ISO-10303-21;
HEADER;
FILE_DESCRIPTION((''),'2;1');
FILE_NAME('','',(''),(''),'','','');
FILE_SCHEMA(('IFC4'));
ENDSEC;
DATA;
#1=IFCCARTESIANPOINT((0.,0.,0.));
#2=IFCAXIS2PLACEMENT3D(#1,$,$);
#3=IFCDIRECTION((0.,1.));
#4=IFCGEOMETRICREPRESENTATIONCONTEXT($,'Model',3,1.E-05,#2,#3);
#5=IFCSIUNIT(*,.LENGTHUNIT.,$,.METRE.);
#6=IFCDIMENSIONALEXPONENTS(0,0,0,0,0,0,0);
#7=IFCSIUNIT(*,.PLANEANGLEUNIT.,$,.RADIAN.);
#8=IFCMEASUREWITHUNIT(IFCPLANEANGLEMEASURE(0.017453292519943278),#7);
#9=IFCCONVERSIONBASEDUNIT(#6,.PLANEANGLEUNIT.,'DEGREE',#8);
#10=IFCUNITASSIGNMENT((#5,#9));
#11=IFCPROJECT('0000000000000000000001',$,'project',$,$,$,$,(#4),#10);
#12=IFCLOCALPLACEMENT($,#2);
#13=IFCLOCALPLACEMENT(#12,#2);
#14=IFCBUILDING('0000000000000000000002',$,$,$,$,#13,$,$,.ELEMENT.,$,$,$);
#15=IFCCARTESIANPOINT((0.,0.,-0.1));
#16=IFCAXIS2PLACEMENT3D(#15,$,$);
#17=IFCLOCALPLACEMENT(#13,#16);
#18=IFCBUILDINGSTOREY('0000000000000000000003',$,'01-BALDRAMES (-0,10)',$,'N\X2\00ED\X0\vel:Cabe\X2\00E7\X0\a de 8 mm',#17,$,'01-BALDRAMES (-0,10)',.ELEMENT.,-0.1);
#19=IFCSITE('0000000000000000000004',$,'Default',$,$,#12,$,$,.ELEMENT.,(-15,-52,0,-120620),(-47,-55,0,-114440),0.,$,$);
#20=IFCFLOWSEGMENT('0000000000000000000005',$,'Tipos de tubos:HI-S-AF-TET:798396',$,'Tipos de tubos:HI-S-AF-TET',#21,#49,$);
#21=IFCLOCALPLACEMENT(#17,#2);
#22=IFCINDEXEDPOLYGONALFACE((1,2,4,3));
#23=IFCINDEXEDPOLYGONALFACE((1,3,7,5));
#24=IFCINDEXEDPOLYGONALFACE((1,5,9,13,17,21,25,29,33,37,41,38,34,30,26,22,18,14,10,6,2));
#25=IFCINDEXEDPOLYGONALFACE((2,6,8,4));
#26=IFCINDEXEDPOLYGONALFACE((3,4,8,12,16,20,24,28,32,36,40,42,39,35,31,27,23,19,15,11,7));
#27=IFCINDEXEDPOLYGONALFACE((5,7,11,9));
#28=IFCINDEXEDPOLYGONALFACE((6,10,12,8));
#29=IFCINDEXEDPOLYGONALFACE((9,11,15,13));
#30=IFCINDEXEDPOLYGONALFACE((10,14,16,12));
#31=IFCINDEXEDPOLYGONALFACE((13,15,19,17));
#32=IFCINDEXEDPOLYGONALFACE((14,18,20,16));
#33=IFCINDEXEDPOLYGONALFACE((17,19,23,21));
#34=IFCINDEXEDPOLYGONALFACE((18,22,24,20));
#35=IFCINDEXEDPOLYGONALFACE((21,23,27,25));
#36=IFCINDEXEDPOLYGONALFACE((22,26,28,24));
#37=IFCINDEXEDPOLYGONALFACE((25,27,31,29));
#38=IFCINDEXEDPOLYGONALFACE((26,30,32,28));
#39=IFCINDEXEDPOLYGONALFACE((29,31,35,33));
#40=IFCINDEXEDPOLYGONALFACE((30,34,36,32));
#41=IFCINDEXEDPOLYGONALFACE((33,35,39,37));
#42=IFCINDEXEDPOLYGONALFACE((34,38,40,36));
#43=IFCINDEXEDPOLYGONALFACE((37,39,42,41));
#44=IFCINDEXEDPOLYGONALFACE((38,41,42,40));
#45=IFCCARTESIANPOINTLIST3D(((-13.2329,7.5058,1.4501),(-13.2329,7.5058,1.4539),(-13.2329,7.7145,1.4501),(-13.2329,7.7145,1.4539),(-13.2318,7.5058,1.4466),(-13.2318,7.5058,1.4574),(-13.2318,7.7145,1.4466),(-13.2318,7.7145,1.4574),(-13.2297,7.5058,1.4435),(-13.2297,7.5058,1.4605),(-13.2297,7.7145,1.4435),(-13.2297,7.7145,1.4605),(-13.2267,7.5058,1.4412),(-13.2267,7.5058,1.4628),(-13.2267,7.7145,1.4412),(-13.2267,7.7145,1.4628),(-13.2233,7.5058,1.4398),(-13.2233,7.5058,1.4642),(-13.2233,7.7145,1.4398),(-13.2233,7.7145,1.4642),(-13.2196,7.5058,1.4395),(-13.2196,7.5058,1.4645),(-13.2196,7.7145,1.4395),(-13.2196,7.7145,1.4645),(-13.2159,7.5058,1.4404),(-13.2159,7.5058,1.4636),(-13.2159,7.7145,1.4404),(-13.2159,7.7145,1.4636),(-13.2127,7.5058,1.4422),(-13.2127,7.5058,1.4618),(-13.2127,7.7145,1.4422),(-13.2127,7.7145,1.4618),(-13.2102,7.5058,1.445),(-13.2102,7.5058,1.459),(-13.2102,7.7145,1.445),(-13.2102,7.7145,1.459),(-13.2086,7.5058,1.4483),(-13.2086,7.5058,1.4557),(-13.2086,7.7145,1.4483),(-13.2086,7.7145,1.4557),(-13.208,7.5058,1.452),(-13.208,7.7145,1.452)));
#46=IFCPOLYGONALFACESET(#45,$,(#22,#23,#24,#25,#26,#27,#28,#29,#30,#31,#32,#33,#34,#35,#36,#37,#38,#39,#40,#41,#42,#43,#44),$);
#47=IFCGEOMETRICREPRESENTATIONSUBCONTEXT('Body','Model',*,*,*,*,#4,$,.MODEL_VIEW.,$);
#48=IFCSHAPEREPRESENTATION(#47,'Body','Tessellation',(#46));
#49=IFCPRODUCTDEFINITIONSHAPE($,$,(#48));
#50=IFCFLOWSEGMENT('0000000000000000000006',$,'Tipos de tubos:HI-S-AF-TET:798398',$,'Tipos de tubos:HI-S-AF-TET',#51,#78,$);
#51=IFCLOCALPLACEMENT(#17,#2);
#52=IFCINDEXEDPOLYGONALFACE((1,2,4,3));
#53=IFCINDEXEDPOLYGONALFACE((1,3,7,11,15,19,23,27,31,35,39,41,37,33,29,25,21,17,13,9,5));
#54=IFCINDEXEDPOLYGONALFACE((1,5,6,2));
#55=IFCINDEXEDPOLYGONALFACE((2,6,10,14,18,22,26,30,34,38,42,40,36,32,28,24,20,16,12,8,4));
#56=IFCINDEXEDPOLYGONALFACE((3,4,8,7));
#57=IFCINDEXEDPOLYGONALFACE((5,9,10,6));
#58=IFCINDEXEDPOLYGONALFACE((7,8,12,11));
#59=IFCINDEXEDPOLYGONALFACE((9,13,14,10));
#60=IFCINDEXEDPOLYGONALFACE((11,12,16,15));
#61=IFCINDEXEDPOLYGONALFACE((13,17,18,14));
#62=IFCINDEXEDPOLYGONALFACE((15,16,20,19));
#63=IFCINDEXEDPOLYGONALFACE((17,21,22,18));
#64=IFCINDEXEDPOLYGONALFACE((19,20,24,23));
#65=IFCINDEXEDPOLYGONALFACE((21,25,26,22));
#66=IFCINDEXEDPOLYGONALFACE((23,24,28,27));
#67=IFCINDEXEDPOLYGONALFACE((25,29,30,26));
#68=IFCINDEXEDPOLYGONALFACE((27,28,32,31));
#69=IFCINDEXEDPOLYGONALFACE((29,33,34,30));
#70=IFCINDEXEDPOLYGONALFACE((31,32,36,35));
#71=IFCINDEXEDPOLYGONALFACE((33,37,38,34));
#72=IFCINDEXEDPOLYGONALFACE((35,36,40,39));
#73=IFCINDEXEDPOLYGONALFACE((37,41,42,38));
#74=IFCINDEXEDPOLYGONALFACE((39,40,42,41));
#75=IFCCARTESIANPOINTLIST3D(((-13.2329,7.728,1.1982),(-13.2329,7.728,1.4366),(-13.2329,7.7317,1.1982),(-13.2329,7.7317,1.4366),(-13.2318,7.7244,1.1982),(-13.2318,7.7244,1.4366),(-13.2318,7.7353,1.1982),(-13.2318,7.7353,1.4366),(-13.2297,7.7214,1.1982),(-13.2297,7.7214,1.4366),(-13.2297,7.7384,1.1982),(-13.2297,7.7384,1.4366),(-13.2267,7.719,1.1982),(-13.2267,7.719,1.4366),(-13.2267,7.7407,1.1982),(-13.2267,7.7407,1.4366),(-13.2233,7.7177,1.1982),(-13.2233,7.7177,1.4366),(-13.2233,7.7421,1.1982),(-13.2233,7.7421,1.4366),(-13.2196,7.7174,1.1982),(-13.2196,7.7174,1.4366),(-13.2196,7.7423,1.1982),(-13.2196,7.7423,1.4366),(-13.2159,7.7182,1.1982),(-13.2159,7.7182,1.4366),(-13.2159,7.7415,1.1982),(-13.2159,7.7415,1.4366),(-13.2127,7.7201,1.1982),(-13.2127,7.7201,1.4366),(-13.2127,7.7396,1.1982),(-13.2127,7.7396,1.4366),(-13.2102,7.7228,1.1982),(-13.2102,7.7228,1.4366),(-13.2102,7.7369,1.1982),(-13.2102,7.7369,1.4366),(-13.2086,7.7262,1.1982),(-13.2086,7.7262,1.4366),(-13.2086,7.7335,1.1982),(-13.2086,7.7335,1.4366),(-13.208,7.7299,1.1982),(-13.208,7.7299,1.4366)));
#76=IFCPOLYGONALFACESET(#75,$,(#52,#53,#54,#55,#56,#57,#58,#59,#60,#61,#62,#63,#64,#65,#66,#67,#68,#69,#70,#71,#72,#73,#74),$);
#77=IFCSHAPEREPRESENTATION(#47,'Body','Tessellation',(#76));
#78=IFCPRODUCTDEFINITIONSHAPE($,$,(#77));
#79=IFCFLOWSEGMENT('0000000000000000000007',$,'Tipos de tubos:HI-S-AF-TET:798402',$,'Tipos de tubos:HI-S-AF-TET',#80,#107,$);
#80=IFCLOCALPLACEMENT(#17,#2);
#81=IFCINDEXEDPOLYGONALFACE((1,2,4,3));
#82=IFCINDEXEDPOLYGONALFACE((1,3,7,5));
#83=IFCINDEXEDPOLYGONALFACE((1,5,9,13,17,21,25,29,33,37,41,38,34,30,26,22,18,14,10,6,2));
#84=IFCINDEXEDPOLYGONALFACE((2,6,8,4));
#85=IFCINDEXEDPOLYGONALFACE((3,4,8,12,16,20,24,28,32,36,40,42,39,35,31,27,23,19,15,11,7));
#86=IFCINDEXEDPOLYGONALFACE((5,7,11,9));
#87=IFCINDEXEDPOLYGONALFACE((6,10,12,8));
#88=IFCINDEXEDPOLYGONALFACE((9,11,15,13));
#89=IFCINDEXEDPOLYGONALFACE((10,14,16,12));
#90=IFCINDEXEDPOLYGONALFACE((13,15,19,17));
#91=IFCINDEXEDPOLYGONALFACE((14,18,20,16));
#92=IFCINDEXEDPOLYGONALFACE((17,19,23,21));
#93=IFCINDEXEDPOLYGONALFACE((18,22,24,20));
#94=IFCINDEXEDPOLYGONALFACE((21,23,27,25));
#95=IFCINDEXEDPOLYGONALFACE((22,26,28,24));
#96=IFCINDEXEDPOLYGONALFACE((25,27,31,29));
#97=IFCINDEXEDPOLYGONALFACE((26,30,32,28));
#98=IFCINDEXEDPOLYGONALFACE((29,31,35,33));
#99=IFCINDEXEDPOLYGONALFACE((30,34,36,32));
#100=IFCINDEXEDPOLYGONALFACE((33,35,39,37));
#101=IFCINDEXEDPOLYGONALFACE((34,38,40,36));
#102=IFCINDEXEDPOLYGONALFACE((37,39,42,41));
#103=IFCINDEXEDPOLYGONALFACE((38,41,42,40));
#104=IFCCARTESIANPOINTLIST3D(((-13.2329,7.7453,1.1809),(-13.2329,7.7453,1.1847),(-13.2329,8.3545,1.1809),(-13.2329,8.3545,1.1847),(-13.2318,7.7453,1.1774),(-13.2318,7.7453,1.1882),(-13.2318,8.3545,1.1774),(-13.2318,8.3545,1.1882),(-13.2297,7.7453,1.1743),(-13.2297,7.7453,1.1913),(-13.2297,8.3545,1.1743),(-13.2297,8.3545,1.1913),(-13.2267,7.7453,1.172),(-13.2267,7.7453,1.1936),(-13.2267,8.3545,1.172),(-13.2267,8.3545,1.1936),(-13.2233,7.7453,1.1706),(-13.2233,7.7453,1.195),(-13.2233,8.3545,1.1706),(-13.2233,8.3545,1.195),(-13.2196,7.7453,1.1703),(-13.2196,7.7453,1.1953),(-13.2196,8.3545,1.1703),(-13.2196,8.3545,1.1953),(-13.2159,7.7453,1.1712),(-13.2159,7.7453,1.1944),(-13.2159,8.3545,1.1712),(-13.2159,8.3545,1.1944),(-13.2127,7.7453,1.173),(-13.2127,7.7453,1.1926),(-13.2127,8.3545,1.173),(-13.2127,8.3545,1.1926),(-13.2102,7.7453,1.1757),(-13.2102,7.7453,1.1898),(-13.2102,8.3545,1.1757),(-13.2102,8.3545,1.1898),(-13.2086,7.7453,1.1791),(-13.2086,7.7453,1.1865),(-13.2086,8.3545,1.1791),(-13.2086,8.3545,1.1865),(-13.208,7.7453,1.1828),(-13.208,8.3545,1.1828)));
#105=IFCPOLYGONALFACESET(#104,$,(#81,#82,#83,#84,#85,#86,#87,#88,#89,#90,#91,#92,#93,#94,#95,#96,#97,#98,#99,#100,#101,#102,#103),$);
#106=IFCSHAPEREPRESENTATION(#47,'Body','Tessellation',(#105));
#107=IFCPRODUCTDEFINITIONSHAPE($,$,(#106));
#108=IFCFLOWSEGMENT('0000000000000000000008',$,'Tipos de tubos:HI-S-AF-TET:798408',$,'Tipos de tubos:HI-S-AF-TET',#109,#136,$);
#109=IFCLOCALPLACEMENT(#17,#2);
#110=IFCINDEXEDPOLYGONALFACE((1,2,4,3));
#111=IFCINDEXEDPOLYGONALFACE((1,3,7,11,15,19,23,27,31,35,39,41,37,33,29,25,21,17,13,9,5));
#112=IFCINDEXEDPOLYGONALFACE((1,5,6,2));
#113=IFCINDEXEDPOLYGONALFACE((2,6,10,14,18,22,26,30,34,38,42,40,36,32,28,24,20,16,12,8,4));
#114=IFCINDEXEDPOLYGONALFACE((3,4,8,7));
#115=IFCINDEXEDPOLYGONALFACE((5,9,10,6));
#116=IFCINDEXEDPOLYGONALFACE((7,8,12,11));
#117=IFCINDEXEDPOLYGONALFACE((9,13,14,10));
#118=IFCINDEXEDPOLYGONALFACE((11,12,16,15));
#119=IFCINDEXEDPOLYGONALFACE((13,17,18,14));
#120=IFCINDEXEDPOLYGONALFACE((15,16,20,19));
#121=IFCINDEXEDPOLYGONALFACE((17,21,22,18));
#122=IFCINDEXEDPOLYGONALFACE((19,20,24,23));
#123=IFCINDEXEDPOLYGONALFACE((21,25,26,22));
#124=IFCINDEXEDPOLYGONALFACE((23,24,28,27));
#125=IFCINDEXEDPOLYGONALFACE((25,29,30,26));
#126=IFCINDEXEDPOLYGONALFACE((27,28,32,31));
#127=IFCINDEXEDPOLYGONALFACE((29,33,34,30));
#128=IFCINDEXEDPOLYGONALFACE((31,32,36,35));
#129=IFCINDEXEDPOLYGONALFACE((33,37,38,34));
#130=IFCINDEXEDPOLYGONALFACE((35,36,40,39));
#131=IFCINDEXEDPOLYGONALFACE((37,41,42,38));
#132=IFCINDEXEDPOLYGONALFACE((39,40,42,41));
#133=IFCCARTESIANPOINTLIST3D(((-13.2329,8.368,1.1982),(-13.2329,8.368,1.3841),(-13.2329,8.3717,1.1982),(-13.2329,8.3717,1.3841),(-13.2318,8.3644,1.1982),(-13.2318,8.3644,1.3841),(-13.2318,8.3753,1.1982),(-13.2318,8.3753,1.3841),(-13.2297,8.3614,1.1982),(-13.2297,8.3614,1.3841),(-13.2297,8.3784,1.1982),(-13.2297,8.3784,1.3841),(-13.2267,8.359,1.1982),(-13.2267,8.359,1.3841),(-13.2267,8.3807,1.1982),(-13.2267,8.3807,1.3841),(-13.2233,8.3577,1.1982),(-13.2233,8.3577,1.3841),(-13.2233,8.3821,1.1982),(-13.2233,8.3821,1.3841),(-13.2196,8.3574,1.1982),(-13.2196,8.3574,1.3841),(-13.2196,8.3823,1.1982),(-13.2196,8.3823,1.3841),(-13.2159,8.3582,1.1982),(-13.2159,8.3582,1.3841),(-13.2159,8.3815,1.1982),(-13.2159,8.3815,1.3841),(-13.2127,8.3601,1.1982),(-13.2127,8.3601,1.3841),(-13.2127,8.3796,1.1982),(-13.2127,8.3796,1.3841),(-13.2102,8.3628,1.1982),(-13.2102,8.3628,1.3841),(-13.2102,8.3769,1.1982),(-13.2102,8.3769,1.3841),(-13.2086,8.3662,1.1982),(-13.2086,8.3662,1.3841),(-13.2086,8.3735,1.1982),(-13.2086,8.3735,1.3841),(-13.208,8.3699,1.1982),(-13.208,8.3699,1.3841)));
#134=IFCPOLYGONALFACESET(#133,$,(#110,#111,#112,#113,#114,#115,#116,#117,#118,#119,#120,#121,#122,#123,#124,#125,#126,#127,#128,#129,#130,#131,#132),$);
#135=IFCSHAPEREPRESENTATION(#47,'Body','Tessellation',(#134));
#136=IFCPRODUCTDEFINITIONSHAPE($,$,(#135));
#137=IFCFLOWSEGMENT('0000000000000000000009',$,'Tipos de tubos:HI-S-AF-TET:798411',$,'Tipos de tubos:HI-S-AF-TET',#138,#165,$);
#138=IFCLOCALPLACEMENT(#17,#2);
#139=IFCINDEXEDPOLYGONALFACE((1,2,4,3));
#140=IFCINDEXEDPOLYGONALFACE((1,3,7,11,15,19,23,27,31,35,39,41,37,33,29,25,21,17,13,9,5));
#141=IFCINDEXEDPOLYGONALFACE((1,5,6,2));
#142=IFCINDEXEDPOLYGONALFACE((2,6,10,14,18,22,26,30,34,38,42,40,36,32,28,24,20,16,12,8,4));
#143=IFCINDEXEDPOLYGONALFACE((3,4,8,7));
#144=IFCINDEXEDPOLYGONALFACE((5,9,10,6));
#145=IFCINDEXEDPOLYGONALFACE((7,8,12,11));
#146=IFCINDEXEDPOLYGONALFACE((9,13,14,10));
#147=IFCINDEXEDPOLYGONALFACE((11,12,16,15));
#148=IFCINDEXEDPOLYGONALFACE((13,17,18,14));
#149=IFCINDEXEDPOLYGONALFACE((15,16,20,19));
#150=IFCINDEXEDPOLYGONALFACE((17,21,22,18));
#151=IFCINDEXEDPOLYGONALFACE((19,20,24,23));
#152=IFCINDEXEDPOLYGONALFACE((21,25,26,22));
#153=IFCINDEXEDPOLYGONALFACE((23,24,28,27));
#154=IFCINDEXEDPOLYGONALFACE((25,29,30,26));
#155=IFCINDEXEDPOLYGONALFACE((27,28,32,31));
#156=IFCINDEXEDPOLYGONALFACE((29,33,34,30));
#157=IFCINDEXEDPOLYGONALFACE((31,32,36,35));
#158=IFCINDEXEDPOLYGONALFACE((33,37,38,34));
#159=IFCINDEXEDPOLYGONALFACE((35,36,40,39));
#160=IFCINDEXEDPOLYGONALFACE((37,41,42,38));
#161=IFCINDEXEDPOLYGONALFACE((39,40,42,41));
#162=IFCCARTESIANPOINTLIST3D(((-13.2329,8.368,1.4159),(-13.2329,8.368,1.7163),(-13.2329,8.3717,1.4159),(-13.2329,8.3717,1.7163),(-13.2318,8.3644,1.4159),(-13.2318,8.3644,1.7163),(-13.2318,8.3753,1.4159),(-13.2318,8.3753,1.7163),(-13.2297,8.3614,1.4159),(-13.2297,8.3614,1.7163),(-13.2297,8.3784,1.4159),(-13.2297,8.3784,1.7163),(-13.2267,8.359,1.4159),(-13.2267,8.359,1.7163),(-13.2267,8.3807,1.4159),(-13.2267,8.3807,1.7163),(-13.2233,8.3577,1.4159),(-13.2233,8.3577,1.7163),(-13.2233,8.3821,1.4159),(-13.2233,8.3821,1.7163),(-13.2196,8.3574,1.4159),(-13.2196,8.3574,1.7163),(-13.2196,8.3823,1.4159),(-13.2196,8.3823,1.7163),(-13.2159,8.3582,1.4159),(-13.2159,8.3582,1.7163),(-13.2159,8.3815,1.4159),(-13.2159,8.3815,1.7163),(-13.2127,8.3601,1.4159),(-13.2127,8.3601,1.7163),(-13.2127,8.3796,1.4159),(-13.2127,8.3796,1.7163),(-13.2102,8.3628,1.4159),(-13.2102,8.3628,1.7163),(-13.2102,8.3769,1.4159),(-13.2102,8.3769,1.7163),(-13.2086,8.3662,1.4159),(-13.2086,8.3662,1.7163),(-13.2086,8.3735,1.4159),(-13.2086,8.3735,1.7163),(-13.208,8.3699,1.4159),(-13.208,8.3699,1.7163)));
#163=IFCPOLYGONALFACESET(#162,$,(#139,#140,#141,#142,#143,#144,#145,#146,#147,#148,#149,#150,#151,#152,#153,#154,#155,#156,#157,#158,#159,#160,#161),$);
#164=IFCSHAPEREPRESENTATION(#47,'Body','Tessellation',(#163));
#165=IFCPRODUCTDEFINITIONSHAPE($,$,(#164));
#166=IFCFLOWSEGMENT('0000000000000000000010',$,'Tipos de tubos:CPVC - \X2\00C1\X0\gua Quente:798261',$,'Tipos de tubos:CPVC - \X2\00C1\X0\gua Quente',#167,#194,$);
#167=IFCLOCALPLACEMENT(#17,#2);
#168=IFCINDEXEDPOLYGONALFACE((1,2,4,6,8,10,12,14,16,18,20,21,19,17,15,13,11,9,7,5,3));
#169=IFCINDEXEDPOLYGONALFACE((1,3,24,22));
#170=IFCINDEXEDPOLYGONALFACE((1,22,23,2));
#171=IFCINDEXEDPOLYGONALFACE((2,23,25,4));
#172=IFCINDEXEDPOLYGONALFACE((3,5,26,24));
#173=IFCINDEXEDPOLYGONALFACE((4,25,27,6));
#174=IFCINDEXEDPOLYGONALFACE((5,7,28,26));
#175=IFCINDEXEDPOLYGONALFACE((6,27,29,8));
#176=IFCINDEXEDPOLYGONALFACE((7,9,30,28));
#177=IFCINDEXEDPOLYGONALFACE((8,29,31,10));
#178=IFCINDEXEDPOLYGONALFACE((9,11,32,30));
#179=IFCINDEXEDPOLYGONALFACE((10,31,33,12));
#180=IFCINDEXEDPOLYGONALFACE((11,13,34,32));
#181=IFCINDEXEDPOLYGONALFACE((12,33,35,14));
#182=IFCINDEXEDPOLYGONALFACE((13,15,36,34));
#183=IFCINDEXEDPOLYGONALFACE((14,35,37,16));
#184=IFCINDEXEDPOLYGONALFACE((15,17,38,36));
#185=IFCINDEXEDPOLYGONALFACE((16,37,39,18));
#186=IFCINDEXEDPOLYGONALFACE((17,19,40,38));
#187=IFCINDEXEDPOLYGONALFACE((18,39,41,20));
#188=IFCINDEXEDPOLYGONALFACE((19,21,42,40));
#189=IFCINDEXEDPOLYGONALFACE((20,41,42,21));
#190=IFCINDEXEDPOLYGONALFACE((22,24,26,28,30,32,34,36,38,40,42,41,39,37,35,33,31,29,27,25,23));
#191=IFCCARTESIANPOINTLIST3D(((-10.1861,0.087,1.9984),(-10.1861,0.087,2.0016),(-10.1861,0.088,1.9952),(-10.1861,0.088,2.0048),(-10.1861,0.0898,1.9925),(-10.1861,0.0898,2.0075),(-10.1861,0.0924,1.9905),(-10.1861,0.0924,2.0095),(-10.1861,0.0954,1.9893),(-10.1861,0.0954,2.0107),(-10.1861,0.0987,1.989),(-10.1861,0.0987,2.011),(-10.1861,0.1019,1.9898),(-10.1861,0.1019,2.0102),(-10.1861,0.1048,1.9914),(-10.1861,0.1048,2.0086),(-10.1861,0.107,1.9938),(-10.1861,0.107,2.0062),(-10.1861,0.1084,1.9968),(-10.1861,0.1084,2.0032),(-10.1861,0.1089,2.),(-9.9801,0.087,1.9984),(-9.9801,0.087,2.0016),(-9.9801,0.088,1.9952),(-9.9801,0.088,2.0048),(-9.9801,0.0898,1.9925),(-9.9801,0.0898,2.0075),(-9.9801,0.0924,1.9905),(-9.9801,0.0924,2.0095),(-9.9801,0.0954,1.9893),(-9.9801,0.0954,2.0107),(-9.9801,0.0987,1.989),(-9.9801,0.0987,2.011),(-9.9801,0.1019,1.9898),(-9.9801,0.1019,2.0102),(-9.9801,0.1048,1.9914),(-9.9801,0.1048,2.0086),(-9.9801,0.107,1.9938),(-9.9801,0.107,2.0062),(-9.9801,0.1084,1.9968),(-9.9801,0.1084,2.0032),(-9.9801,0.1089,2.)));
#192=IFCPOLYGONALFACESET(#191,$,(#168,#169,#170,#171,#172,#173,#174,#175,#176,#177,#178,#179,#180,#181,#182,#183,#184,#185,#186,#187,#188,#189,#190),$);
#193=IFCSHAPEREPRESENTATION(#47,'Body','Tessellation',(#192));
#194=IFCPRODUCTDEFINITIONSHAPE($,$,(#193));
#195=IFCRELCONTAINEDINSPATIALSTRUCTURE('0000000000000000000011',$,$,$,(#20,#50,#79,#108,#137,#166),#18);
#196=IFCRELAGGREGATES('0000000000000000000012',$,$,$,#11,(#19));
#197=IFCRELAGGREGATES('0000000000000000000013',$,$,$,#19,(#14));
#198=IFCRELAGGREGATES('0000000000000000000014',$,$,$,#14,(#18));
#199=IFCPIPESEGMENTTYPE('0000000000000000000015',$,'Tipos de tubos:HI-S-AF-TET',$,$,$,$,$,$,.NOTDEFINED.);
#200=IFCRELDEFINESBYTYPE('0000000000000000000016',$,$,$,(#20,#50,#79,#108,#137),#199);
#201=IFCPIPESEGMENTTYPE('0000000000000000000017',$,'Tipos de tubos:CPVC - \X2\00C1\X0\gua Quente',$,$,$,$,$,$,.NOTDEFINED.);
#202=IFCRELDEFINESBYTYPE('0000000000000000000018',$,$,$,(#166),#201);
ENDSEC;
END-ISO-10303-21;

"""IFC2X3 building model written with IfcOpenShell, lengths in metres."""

from ifc_helpers import new_model, entity, si_unit, converted_unit, direction, frame, frame_2d, origin, origin_2d_with_axis, place, context, subcontext, project, spatial, circle, extrude, type_object, element, save


model = new_model("IFC2X3")

# Units and contexts
model_context = context("Model", 3, precision=1e-05, world=origin(), true_north=direction((0.0, 1.0)))
body_context = subcontext(model_context, "Body", "Model", "MODEL_VIEW")
ifc_project = project(units=[si_unit("LENGTHUNIT", "METRE"), converted_unit("PLANEANGLEUNIT", "DEGREE", entity("IfcPlaneAngleMeasure", 0.017453292519943278), si_unit("PLANEANGLEUNIT", "RADIAN"), dimensions=[0, 0, 0, 0, 0, 0, 0])], contexts=[model_context])

# Site, building, storey
site_placement = place(None, origin())
site = spatial("IfcSite", under=ifc_project, at=site_placement, Name="Default", CompositionType="ELEMENT", RefLatitude=(-15, -52, 0, -120620), RefLongitude=(-47, -55, 0, -114440), RefElevation=0.0)
building_placement = place(site_placement, origin())
building = spatial("IfcBuilding", under=site, at=building_placement, CompositionType="ELEMENT")
storey_placement = place(building_placement, frame((0.0, 0.0, -0.1)))
storey = spatial("IfcBuildingStorey", under=building, at=storey_placement, Name="01-BALDRAMES (-0,10)", ObjectType="Nível:Cabeça de 8 mm", LongName="01-BALDRAMES (-0,10)", CompositionType="ELEMENT", Elevation=-0.1)

# Flow segments
pipe_segment_type_1 = type_object("IfcPipeSegmentType", Name="Tipos de tubos:HI-S-AF-TET", PredefinedType="NOTDEFINED")
flow_segment_1_placement = place(storey_placement, origin())
element("IfcFlowSegment", 1, at=flow_segment_1_placement, inside=storey, type_object=pipe_segment_type_1, Name="Tipos de tubos:HI-S-AF-TET:798396", ObjectType="Tipos de tubos:HI-S-AF-TET", context=body_context, shape_type="SweptSolid", body=[
    extrude(circle(Radius=0.0125, at=origin_2d_with_axis()), frame((-13.2205, 7.5058, 1.452), z_axis=(0.0, 1.0, 0.0), x_axis=(1.0, 0.0, 0.0)), (0.0, 0.0, 1.0), 0.2087),
])
flow_segment_2_placement = place(storey_placement, origin())
element("IfcFlowSegment", 2, at=flow_segment_2_placement, inside=storey, type_object=pipe_segment_type_1, Name="Tipos de tubos:HI-S-AF-TET:798398", ObjectType="Tipos de tubos:HI-S-AF-TET", context=body_context, shape_type="SweptSolid", body=[
    extrude(circle(Radius=0.0125, at=origin_2d_with_axis()), frame((-13.2205, 7.7299, 1.1982)), (0.0, 0.0, 1.0), 0.2384),
])
flow_segment_3_placement = place(storey_placement, origin())
element("IfcFlowSegment", 3, at=flow_segment_3_placement, inside=storey, type_object=pipe_segment_type_1, Name="Tipos de tubos:HI-S-AF-TET:798402", ObjectType="Tipos de tubos:HI-S-AF-TET", context=body_context, shape_type="SweptSolid", body=[
    extrude(circle(Radius=0.0125, at=origin_2d_with_axis()), frame((-13.2205, 7.7453, 1.1828), z_axis=(0.0, 1.0, 0.0), x_axis=(1.0, 0.0, 0.0)), (0.0, 0.0, 1.0), 0.6092),
])
flow_segment_4_placement = place(storey_placement, origin())
element("IfcFlowSegment", 4, at=flow_segment_4_placement, inside=storey, type_object=pipe_segment_type_1, Name="Tipos de tubos:HI-S-AF-TET:798408", ObjectType="Tipos de tubos:HI-S-AF-TET", context=body_context, shape_type="SweptSolid", body=[
    extrude(circle(Radius=0.0125, at=origin_2d_with_axis()), frame((-13.2205, 8.3699, 1.1982)), (0.0, 0.0, 1.0), 0.1859),
])
flow_segment_5_placement = place(storey_placement, origin())
element("IfcFlowSegment", 5, at=flow_segment_5_placement, inside=storey, type_object=pipe_segment_type_1, Name="Tipos de tubos:HI-S-AF-TET:798411", ObjectType="Tipos de tubos:HI-S-AF-TET", context=body_context, shape_type="SweptSolid", body=[
    extrude(circle(Radius=0.0125, at=origin_2d_with_axis()), frame((-13.2205, 8.3699, 1.4159)), (0.0, 0.0, 1.0), 0.3004),
])
pipe_segment_type_2 = type_object("IfcPipeSegmentType", Name="Tipos de tubos:CPVC - Água Quente", PredefinedType="NOTDEFINED")
flow_segment_6_placement = place(storey_placement, origin())
element("IfcFlowSegment", 6, at=flow_segment_6_placement, inside=storey, type_object=pipe_segment_type_2, Name="Tipos de tubos:CPVC - Água Quente:798261", ObjectType="Tipos de tubos:CPVC - Água Quente", context=body_context, shape_type="SweptSolid", body=[
    extrude(circle(Radius=0.011, at=frame_2d((0.0, 0.0), x_axis=(1.0, 0.0))), frame((-10.1861, 0.0979, 2.0), z_axis=(1.0, 0.0, 0.0), x_axis=(0.0, 1.0, 0.0)), (0.0, 0.0, 1.0), 0.206),
])

save(model, "model.ifc")
